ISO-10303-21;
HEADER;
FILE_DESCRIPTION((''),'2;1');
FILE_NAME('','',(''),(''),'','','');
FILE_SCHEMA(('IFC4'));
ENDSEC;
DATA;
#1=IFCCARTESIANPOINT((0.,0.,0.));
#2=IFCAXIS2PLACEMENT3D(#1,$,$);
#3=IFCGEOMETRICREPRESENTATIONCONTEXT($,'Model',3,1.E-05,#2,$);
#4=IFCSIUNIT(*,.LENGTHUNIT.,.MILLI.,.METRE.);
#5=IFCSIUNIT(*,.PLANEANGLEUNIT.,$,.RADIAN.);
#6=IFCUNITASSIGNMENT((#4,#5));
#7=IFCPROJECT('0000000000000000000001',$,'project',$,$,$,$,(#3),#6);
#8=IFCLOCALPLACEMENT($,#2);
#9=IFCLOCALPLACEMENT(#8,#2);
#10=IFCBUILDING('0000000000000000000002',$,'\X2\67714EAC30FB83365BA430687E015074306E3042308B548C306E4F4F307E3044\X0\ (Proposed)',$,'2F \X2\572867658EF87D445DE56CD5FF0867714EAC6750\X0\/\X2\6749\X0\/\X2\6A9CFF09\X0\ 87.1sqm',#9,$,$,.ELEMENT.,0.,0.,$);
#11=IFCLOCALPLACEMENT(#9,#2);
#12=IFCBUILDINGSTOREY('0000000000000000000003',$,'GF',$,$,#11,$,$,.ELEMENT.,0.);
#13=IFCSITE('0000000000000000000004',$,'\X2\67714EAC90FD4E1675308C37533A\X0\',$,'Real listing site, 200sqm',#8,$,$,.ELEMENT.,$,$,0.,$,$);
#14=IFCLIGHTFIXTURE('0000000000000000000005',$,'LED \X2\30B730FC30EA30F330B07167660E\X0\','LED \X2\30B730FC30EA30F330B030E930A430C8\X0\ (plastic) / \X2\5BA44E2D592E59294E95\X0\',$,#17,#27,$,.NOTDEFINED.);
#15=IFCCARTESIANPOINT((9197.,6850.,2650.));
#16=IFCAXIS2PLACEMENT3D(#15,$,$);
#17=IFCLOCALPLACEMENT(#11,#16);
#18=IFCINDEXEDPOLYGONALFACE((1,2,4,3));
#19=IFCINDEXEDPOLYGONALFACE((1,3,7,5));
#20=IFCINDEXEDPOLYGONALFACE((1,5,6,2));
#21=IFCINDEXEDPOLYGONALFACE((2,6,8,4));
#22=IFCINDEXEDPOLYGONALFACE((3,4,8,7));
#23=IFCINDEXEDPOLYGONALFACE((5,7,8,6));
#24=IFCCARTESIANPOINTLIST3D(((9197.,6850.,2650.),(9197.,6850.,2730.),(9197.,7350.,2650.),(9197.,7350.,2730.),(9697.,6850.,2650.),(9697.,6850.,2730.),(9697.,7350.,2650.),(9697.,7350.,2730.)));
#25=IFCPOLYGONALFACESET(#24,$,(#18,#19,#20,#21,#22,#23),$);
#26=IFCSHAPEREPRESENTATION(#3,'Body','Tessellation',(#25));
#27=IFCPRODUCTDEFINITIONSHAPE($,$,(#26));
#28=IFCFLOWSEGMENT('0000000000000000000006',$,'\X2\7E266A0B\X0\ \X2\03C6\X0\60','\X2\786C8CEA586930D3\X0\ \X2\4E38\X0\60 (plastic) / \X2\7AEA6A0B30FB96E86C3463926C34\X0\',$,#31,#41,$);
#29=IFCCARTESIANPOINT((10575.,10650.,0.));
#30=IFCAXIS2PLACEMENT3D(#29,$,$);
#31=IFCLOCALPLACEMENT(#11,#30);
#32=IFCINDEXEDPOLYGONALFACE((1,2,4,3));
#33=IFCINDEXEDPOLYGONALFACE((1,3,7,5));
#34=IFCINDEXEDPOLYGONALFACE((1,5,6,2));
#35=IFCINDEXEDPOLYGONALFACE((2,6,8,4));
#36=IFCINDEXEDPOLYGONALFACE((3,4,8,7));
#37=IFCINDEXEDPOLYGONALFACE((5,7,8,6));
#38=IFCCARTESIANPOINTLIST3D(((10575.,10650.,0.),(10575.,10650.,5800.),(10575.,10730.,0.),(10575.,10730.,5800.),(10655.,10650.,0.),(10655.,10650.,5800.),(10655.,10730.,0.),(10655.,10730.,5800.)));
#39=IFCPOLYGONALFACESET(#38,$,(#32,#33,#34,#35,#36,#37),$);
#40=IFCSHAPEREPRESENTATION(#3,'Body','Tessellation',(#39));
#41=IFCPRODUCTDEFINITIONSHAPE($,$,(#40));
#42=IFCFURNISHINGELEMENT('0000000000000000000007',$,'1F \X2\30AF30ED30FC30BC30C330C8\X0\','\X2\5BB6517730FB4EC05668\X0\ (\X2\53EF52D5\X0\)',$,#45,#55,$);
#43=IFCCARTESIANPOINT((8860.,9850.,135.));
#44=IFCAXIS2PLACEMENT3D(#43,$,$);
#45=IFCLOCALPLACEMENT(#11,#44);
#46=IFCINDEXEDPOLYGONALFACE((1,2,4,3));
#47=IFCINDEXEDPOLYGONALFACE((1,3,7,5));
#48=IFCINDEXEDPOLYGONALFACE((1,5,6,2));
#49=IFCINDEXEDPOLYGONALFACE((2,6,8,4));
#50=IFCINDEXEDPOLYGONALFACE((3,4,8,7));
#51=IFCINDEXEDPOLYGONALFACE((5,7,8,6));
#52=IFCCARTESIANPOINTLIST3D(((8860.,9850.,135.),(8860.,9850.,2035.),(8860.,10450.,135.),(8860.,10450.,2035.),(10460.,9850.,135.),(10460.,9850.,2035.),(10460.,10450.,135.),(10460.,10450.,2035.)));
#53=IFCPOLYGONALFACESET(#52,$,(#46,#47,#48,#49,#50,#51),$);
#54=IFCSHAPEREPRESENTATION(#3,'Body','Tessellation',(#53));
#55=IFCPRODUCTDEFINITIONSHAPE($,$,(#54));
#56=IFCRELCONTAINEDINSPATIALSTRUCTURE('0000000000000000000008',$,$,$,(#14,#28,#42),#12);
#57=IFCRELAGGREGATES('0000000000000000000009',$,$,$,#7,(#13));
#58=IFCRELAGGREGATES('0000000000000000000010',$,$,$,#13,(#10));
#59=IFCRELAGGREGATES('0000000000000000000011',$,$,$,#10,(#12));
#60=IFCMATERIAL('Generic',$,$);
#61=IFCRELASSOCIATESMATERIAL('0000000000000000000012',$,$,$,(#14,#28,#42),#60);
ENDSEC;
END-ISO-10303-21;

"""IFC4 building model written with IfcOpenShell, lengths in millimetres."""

from ifc_helpers import new_model, si_unit, frame, frame_2d, origin, place, context, project, spatial, rectangle, extrude, material, element, save


model = new_model("IFC4")

# Units and contexts
model_context = context("Model", 3, precision=1e-05, world=origin())
ifc_project = project(units=[si_unit("LENGTHUNIT", "METRE", prefix="MILLI"), si_unit("PLANEANGLEUNIT", "RADIAN")], contexts=[model_context])

# Site, building, storey
site_placement = place(None, origin())
site = spatial("IfcSite", under=ifc_project, at=site_placement, Name="東京都世田谷区", ObjectType="Real listing site, 200sqm", CompositionType="ELEMENT", RefElevation=0.0)
building_placement = place(site_placement, origin())
building = spatial("IfcBuilding", under=site, at=building_placement, Name="東京・茶室と縁側のある和の住まい (Proposed)", ObjectType="2F 在来軸組工法（東京材/杉/檜） 87.1sqm", CompositionType="ELEMENT", ElevationOfRefHeight=0.0, ElevationOfTerrain=0.0)
storey_placement = place(building_placement, origin())
storey = spatial("IfcBuildingStorey", under=building, at=storey_placement, Name="GF", CompositionType="ELEMENT", Elevation=0.0)

# Shared definitions
ifc_material_1 = material(Name="Generic")

# Light fixture
light_fixture_placement = place(storey_placement, frame((9197.0, 6850.0, 2650.0)))
element("IfcLightFixture", 1, at=light_fixture_placement, inside=storey, material=ifc_material_1, Name="LED シーリング照明", Description="LED シーリングライト (plastic) / 室中央天井", PredefinedType="NOTDEFINED", context=model_context, shape_type="SweptSolid", body=[
    extrude(rectangle(XDim=500.0, YDim=500.0, at=frame_2d((250.0, 250.0))), frame((9197.0, 6850.0, 2650.0)), (0.0, 0.0, 1.0), 80.0),
])

# Flow segment
flow_segment_placement = place(storey_placement, frame((10575.0, 10650.0, 0.0)))
element("IfcFlowSegment", 2, at=flow_segment_placement, inside=storey, material=ifc_material_1, Name="縦樋 φ60", Description="硬質塩ビ 丸60 (plastic) / 竪樋・雨水排水", context=model_context, shape_type="SweptSolid", body=[
    extrude(rectangle(XDim=80.0, YDim=80.0, at=frame_2d((40.0, 40.0))), frame((10575.0, 10650.0, 0.0)), (0.0, 0.0, 1.0), 5800.0),
])

# Furnishing element
furnishing_placement = place(storey_placement, frame((8860.0, 9850.0, 135.0)))
element("IfcFurnishingElement", 3, at=furnishing_placement, inside=storey, material=ifc_material_1, Name="1F クローゼット", Description="家具・什器 (可動)", context=model_context, shape_type="SweptSolid", body=[
    extrude(rectangle(XDim=1600.0, YDim=600.0, at=frame_2d((800.0, 300.0))), frame((8860.0, 9850.0, 135.0)), (0.0, 0.0, 1.0), 1900.0),
])

save(model, "model.ifc")
